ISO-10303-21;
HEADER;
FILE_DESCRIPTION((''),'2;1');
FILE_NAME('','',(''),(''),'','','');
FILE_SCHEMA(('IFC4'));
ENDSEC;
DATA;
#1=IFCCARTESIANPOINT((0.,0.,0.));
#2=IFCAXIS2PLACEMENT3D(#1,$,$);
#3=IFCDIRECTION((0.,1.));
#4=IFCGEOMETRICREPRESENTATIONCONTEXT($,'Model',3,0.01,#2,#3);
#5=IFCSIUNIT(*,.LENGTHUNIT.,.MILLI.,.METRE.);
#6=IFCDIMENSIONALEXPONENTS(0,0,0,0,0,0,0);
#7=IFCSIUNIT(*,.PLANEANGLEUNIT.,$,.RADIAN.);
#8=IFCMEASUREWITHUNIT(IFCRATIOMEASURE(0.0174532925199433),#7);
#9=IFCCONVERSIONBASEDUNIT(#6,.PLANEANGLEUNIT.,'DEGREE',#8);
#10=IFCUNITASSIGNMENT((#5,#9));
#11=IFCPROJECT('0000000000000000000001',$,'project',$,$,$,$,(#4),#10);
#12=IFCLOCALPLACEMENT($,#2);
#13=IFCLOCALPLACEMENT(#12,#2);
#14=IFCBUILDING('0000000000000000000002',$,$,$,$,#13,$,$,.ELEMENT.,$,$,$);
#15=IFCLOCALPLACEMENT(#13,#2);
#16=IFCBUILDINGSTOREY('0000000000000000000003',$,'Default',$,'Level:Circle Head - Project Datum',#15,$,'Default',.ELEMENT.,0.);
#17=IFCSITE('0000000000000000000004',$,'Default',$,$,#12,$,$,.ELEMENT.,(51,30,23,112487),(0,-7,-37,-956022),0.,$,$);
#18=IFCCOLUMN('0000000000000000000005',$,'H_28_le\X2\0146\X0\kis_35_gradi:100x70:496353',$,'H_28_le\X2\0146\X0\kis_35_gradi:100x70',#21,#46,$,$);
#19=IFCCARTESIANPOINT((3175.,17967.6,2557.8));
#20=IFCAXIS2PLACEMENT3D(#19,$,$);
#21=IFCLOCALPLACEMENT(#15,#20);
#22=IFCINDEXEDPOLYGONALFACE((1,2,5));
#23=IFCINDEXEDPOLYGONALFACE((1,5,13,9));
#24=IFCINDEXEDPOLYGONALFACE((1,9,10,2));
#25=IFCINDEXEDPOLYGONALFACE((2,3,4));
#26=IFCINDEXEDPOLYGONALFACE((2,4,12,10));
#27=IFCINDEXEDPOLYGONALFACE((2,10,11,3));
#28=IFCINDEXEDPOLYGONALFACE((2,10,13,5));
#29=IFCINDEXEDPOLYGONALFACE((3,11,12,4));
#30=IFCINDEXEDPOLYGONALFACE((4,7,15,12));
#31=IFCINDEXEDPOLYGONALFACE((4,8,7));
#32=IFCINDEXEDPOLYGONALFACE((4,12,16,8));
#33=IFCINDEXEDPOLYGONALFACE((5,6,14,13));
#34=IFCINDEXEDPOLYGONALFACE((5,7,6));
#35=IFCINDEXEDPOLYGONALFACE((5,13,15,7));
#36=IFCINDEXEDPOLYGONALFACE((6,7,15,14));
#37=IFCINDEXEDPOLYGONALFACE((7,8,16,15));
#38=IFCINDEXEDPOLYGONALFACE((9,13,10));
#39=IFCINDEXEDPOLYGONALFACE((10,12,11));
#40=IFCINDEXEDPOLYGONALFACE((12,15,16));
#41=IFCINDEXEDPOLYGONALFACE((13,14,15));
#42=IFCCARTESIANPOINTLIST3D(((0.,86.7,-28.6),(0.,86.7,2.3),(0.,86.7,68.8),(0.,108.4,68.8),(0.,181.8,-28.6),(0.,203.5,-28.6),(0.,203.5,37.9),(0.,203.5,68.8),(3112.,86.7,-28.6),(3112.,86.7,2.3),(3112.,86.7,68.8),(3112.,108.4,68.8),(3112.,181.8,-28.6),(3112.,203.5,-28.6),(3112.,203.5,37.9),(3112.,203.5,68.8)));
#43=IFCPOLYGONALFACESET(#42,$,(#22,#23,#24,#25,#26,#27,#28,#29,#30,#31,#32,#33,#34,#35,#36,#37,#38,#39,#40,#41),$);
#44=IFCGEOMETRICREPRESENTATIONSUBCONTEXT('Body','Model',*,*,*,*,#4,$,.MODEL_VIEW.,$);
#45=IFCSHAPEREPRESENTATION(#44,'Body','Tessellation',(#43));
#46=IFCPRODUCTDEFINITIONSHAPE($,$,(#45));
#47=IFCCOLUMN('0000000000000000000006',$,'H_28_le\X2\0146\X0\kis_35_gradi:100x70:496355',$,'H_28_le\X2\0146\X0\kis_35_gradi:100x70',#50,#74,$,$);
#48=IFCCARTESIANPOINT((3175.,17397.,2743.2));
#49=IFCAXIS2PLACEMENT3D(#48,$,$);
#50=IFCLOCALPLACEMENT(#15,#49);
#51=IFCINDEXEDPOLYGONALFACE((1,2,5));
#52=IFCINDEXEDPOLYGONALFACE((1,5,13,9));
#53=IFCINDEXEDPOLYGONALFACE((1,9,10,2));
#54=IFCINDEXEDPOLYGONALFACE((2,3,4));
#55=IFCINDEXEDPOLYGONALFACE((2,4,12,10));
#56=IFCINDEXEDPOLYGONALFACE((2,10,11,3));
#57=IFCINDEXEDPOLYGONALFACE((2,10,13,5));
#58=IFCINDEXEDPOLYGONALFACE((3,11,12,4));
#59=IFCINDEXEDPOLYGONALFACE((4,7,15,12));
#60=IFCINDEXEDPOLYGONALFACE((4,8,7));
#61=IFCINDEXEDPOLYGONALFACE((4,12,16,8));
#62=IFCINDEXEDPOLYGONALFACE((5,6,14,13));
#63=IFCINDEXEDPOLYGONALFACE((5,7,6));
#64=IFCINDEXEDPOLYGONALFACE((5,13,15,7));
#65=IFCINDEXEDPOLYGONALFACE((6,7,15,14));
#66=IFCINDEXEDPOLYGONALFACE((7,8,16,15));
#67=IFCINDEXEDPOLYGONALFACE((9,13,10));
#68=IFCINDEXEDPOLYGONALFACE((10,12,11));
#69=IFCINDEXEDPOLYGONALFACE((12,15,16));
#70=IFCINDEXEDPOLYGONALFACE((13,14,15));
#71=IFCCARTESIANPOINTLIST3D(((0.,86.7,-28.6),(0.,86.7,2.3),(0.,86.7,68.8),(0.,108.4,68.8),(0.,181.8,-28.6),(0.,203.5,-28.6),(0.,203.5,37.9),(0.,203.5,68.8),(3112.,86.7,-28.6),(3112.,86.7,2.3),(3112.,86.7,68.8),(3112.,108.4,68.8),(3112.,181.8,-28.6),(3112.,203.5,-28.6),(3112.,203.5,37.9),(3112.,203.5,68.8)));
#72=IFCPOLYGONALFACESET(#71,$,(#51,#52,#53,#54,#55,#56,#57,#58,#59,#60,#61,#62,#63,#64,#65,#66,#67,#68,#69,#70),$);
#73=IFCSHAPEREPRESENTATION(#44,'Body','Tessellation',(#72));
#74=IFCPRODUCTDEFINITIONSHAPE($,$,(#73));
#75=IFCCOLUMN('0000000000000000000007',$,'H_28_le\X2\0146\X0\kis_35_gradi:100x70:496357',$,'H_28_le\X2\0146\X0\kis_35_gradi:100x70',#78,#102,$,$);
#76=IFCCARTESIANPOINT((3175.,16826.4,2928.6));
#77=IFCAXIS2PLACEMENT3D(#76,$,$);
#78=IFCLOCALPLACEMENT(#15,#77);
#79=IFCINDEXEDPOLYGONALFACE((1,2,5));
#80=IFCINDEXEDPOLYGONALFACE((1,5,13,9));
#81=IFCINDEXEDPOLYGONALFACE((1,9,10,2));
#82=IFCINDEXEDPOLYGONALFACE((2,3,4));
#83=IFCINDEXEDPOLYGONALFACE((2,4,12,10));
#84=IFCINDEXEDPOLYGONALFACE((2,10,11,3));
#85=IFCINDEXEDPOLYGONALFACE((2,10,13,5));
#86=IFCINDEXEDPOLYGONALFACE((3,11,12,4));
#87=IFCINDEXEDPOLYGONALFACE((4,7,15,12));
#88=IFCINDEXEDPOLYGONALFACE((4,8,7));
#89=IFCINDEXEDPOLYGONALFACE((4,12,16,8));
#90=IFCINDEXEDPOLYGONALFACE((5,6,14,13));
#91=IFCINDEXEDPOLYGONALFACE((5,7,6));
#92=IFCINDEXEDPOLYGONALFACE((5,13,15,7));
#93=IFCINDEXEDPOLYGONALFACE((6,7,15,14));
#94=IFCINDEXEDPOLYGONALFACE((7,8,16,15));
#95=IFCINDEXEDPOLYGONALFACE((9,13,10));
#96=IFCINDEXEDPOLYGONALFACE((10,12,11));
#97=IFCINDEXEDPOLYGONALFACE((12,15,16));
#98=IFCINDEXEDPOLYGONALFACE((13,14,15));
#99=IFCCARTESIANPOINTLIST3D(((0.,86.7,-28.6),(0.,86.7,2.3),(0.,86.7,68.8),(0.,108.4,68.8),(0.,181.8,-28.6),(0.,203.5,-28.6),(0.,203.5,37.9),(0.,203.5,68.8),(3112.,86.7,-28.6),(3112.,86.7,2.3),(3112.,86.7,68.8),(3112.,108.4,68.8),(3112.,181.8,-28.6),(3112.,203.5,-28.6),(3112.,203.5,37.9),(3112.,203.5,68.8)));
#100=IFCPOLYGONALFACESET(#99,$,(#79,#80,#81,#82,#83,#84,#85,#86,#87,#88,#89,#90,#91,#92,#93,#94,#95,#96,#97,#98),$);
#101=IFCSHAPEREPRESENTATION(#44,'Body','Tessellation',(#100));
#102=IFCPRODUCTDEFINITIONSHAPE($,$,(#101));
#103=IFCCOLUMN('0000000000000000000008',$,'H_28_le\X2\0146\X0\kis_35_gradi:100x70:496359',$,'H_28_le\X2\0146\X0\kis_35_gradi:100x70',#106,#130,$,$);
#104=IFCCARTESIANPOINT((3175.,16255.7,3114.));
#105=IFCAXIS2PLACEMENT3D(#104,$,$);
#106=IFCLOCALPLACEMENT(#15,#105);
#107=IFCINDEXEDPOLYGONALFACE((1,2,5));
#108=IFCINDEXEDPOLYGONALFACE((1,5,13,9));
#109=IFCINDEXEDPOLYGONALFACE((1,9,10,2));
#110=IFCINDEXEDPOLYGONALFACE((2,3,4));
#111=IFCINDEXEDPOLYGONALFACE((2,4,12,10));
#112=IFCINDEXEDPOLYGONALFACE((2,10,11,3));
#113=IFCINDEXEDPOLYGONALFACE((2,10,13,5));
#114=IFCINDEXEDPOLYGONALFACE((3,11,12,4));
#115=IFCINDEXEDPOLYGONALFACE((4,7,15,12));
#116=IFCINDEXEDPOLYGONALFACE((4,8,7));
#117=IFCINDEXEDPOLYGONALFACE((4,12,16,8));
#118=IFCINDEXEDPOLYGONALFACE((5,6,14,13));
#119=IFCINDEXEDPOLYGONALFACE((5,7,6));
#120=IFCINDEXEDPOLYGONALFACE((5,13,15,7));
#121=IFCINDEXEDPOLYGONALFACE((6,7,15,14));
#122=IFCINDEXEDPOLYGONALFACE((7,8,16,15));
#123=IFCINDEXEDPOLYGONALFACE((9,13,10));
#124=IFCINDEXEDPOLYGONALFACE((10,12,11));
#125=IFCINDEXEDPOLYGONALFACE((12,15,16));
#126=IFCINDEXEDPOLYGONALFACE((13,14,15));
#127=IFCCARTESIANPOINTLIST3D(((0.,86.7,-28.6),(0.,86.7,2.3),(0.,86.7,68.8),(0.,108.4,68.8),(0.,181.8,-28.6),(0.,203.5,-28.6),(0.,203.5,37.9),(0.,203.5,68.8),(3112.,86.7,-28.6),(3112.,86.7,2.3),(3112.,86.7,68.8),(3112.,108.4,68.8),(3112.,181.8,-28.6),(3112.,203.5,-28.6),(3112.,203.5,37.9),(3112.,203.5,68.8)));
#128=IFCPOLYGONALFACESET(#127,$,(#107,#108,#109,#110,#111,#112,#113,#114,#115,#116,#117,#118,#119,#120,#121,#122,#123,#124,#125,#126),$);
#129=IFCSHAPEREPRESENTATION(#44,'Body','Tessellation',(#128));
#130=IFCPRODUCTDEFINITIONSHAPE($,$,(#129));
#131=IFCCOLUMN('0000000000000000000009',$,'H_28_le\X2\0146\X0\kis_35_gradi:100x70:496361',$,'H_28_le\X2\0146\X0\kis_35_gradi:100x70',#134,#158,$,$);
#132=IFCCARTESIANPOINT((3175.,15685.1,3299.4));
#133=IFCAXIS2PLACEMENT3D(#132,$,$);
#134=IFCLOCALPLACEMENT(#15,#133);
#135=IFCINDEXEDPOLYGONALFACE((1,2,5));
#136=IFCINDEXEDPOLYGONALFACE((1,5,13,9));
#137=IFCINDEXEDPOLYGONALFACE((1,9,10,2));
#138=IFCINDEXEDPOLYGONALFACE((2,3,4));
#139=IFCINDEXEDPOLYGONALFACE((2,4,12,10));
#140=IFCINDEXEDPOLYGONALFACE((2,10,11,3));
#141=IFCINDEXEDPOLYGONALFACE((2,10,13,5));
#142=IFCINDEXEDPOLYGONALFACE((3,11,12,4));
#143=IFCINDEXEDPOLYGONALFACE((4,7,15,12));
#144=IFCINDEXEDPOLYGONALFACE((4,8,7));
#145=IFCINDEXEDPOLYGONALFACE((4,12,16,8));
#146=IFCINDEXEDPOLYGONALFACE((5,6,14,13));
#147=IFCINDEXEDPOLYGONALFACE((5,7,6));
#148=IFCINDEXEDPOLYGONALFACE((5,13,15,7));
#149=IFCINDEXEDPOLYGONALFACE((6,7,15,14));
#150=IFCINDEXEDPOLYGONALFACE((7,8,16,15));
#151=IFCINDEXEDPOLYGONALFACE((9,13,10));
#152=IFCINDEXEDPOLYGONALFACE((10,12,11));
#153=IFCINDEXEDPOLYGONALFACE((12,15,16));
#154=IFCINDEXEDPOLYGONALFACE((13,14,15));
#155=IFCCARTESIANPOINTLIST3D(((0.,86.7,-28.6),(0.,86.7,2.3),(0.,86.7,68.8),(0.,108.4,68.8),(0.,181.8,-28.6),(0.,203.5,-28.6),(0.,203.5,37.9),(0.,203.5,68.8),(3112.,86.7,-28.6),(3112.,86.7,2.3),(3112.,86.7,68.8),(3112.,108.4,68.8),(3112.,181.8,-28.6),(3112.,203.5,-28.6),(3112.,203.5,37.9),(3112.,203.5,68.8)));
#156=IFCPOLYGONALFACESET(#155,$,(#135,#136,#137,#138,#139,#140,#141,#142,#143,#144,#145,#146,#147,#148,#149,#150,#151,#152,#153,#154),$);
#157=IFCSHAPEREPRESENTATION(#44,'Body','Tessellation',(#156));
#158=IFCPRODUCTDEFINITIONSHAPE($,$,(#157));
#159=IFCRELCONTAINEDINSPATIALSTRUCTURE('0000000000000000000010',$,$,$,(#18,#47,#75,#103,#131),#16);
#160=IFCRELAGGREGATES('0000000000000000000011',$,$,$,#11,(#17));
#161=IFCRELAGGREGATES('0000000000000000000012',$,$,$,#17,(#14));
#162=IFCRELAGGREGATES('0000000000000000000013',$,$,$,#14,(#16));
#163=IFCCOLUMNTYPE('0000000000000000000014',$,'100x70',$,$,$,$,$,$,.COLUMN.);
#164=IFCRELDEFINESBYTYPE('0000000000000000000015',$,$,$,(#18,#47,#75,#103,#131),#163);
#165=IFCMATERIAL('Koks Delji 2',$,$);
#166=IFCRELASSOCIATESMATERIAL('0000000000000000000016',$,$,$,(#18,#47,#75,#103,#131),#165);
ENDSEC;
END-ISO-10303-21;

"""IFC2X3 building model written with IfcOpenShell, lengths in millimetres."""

from ifc_helpers import new_model, entity, si_unit, converted_unit, direction, frame, frame_2d, origin, origin_2d_with_axis, place, context, subcontext, project, spatial, rectangle, extrude, boolean, source, transform, mapped, material, type_object, type_shapes, element, save


model = new_model("IFC2X3")

# Units and contexts
model_context = context("Model", 3, precision=0.01, world=origin(), true_north=direction((0.0, 1.0)))
body_context = subcontext(model_context, "Body", "Model", "MODEL_VIEW")
ifc_project = project(units=[si_unit("LENGTHUNIT", "METRE", prefix="MILLI"), converted_unit("PLANEANGLEUNIT", "DEGREE", entity("IfcRatioMeasure", 0.0174532925199433), si_unit("PLANEANGLEUNIT", "RADIAN"), dimensions=[0, 0, 0, 0, 0, 0, 0])], contexts=[model_context])

# Site, building, storey
site_placement = place(None, origin())
site = spatial("IfcSite", under=ifc_project, at=site_placement, Name="Default", CompositionType="ELEMENT", RefLatitude=(51, 30, 23, 112487), RefLongitude=(0, -7, -37, -956022), RefElevation=0.0)
building_placement = place(site_placement, origin())
building = spatial("IfcBuilding", under=site, at=building_placement, CompositionType="ELEMENT")
storey_placement = place(building_placement, origin())
storey = spatial("IfcBuildingStorey", under=building, at=storey_placement, Name="Default", ObjectType="Level:Circle Head - Project Datum", LongName="Default", CompositionType="ELEMENT", Elevation=0.0)

# Columns
ifc_material_1 = material(Name="Koks Delji 2")
column_type = type_object("IfcColumnType", Name="100x70", PredefinedType="COLUMN")
shared_shape_1 = source(origin(), body_context, "Body", "CSG", [
    boolean("DIFFERENCE", extrude(rectangle(XDim=3112.0, YDim=116.7, at=origin_2d_with_axis()), frame((1556.0, 145.1, -28.6)), (0.0, 0.0, 1.0), 97.5), extrude(rectangle(XDim=70.0, YDim=100.0, at=frame_2d((0.0, 0.0), x_axis=(0.0, 1.0))), frame((3112.0, 145.1, 20.1), z_axis=(1.0, 0.0, 0.0), x_axis=(0.0, 0.951057, -0.309017)), (0.0, 0.0, -1.0), 3112.0)),
])
type_shapes(column_type, [shared_shape_1])
for number, where, name in (
    (1, (3175.0, 17967.6, 2557.8), "H_28_leņkis_35_gradi:100x70:496353"),
    (2, (3175.0, 17397.0, 2743.2), "H_28_leņkis_35_gradi:100x70:496355"),
    (3, (3175.0, 16826.4, 2928.6), "H_28_leņkis_35_gradi:100x70:496357"),
    (4, (3175.0, 16255.7, 3114.0), "H_28_leņkis_35_gradi:100x70:496359"),
    (5, (3175.0, 15685.1, 3299.4), "H_28_leņkis_35_gradi:100x70:496361"),
):
    element("IfcColumn", number, at=place(storey_placement, frame(where)), inside=storey, type_object=column_type, material=ifc_material_1, Name=name, ObjectType="H_28_leņkis_35_gradi:100x70", context=body_context, shape_type="MappedRepresentation", body=[
        mapped(shared_shape_1, transform((0.0, 0.0, 0.0), scale=1.0)),
    ])

save(model, "model.ifc")
